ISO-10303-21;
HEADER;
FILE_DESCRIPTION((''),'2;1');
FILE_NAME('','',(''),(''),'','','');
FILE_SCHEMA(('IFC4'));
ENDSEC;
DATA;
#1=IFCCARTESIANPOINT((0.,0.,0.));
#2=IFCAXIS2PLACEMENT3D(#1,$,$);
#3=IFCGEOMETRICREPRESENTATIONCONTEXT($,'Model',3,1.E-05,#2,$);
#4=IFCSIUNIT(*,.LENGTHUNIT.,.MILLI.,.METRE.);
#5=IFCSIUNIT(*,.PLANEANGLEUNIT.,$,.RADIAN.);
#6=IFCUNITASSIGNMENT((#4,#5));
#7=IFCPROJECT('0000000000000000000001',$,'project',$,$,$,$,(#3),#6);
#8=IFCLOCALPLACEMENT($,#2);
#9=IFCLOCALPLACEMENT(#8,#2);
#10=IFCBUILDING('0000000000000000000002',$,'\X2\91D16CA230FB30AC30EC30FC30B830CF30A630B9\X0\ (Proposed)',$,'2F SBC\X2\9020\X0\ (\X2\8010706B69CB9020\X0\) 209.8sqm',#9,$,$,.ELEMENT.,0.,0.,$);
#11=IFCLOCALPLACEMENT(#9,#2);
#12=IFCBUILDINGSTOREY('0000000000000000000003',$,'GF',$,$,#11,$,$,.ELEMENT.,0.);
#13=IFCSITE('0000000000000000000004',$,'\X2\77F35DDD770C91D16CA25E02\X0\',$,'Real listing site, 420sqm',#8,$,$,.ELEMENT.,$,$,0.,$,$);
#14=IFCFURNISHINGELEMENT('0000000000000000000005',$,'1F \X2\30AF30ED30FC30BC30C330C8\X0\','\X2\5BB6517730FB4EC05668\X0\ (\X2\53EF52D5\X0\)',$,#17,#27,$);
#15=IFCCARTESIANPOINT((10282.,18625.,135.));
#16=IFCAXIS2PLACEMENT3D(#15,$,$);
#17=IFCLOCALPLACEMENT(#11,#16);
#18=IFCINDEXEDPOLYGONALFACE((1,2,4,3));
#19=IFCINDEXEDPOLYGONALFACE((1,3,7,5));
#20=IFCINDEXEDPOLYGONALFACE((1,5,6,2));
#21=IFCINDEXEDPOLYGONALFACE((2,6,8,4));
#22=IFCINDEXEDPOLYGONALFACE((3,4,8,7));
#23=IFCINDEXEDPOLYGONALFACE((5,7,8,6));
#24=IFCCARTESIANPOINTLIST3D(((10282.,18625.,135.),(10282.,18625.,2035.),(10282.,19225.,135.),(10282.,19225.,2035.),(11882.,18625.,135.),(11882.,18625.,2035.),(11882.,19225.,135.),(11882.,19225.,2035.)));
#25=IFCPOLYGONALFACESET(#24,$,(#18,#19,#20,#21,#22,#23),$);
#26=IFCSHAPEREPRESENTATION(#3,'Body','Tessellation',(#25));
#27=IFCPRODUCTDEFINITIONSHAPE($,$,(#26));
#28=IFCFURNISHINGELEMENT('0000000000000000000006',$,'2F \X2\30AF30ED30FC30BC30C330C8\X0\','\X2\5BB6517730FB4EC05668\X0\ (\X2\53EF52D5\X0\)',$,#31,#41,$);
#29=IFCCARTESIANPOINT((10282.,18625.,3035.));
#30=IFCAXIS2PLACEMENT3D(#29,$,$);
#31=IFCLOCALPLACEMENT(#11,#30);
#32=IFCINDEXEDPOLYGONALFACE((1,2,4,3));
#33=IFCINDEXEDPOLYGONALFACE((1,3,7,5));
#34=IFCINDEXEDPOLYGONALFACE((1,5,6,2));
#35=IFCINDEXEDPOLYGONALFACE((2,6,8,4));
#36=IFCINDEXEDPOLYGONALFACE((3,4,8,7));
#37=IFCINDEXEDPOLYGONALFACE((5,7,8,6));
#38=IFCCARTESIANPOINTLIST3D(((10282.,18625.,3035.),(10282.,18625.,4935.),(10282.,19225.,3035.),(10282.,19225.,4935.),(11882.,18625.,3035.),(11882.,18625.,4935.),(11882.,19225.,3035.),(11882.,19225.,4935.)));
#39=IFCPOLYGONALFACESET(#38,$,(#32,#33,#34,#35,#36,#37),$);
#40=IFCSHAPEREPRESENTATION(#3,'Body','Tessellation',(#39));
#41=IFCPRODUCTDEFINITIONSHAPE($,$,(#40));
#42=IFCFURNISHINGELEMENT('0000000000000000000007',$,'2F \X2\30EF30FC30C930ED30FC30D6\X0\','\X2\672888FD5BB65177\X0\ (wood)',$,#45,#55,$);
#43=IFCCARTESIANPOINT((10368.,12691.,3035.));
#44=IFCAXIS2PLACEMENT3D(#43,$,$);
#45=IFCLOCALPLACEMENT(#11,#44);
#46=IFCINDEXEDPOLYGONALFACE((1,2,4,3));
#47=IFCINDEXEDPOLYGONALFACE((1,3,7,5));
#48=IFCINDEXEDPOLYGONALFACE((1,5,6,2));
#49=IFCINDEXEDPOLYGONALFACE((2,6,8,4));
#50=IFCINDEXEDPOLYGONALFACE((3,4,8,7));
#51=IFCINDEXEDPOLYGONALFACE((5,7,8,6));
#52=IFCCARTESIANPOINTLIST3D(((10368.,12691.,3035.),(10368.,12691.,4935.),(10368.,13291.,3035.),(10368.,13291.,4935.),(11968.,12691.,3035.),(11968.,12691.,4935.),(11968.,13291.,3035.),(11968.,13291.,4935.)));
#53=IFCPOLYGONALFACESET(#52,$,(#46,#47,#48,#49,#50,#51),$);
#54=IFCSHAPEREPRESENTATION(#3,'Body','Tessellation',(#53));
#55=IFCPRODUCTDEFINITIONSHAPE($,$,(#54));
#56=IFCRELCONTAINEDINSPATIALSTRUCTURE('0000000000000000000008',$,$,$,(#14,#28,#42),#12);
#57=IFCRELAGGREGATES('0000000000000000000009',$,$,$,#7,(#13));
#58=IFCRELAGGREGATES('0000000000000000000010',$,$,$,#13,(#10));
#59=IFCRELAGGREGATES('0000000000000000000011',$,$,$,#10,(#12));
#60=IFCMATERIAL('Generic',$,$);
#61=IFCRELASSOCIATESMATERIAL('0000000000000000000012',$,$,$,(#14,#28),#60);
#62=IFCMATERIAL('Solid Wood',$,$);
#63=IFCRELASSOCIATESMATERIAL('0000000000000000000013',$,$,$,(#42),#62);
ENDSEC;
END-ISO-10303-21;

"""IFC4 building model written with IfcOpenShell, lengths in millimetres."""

from ifc_helpers import new_model, si_unit, frame, frame_2d, origin, place, context, project, spatial, rectangle, extrude, material, element, save


model = new_model("IFC4")

# Units and contexts
model_context = context("Model", 3, precision=1e-05, world=origin())
ifc_project = project(units=[si_unit("LENGTHUNIT", "METRE", prefix="MILLI"), si_unit("PLANEANGLEUNIT", "RADIAN")], contexts=[model_context])

# Site, building, storey
site_placement = place(None, origin())
site = spatial("IfcSite", under=ifc_project, at=site_placement, Name="石川県金沢市", ObjectType="Real listing site, 420sqm", CompositionType="ELEMENT", RefElevation=0.0)
building_placement = place(site_placement, origin())
building = spatial("IfcBuilding", under=site, at=building_placement, Name="金沢・ガレージハウス (Proposed)", ObjectType="2F SBC造 (耐火構造) 209.8sqm", CompositionType="ELEMENT", ElevationOfRefHeight=0.0, ElevationOfTerrain=0.0)
storey_placement = place(building_placement, origin())
storey = spatial("IfcBuildingStorey", under=building, at=storey_placement, Name="GF", CompositionType="ELEMENT", Elevation=0.0)

# Shared definitions
ifc_material_1 = material(Name="Solid Wood")

# Shared definitions
ifc_material_2 = material(Name="Generic")

# Furnishing elements
furnishing_1_placement = place(storey_placement, frame((10282.0, 18625.0, 135.0)))
element("IfcFurnishingElement", 1, at=furnishing_1_placement, inside=storey, material=ifc_material_2, Name="1F クローゼット", Description="家具・什器 (可動)", context=model_context, shape_type="SweptSolid", body=[
    extrude(rectangle(XDim=1600.0, YDim=600.0, at=frame_2d((800.0, 300.0))), frame((10282.0, 18625.0, 135.0)), (0.0, 0.0, 1.0), 1900.0),
])
furnishing_2_placement = place(storey_placement, frame((10282.0, 18625.0, 3035.0)))
element("IfcFurnishingElement", 2, at=furnishing_2_placement, inside=storey, material=ifc_material_2, Name="2F クローゼット", Description="家具・什器 (可動)", context=model_context, shape_type="SweptSolid", body=[
    extrude(rectangle(XDim=1600.0, YDim=600.0, at=frame_2d((800.0, 300.0))), frame((10282.0, 18625.0, 3035.0)), (0.0, 0.0, 1.0), 1900.0),
])
furnishing_3_placement = place(storey_placement, frame((10368.0, 12691.0, 3035.0)))
element("IfcFurnishingElement", 3, at=furnishing_3_placement, inside=storey, material=ifc_material_1, Name="2F ワードローブ", Description="木製家具 (wood)", context=model_context, shape_type="SweptSolid", body=[
    extrude(rectangle(XDim=1600.0, YDim=600.0, at=frame_2d((800.0, 300.0))), frame((10368.0, 12691.0, 3035.0)), (0.0, 0.0, 1.0), 1900.0),
])

save(model, "model.ifc")
